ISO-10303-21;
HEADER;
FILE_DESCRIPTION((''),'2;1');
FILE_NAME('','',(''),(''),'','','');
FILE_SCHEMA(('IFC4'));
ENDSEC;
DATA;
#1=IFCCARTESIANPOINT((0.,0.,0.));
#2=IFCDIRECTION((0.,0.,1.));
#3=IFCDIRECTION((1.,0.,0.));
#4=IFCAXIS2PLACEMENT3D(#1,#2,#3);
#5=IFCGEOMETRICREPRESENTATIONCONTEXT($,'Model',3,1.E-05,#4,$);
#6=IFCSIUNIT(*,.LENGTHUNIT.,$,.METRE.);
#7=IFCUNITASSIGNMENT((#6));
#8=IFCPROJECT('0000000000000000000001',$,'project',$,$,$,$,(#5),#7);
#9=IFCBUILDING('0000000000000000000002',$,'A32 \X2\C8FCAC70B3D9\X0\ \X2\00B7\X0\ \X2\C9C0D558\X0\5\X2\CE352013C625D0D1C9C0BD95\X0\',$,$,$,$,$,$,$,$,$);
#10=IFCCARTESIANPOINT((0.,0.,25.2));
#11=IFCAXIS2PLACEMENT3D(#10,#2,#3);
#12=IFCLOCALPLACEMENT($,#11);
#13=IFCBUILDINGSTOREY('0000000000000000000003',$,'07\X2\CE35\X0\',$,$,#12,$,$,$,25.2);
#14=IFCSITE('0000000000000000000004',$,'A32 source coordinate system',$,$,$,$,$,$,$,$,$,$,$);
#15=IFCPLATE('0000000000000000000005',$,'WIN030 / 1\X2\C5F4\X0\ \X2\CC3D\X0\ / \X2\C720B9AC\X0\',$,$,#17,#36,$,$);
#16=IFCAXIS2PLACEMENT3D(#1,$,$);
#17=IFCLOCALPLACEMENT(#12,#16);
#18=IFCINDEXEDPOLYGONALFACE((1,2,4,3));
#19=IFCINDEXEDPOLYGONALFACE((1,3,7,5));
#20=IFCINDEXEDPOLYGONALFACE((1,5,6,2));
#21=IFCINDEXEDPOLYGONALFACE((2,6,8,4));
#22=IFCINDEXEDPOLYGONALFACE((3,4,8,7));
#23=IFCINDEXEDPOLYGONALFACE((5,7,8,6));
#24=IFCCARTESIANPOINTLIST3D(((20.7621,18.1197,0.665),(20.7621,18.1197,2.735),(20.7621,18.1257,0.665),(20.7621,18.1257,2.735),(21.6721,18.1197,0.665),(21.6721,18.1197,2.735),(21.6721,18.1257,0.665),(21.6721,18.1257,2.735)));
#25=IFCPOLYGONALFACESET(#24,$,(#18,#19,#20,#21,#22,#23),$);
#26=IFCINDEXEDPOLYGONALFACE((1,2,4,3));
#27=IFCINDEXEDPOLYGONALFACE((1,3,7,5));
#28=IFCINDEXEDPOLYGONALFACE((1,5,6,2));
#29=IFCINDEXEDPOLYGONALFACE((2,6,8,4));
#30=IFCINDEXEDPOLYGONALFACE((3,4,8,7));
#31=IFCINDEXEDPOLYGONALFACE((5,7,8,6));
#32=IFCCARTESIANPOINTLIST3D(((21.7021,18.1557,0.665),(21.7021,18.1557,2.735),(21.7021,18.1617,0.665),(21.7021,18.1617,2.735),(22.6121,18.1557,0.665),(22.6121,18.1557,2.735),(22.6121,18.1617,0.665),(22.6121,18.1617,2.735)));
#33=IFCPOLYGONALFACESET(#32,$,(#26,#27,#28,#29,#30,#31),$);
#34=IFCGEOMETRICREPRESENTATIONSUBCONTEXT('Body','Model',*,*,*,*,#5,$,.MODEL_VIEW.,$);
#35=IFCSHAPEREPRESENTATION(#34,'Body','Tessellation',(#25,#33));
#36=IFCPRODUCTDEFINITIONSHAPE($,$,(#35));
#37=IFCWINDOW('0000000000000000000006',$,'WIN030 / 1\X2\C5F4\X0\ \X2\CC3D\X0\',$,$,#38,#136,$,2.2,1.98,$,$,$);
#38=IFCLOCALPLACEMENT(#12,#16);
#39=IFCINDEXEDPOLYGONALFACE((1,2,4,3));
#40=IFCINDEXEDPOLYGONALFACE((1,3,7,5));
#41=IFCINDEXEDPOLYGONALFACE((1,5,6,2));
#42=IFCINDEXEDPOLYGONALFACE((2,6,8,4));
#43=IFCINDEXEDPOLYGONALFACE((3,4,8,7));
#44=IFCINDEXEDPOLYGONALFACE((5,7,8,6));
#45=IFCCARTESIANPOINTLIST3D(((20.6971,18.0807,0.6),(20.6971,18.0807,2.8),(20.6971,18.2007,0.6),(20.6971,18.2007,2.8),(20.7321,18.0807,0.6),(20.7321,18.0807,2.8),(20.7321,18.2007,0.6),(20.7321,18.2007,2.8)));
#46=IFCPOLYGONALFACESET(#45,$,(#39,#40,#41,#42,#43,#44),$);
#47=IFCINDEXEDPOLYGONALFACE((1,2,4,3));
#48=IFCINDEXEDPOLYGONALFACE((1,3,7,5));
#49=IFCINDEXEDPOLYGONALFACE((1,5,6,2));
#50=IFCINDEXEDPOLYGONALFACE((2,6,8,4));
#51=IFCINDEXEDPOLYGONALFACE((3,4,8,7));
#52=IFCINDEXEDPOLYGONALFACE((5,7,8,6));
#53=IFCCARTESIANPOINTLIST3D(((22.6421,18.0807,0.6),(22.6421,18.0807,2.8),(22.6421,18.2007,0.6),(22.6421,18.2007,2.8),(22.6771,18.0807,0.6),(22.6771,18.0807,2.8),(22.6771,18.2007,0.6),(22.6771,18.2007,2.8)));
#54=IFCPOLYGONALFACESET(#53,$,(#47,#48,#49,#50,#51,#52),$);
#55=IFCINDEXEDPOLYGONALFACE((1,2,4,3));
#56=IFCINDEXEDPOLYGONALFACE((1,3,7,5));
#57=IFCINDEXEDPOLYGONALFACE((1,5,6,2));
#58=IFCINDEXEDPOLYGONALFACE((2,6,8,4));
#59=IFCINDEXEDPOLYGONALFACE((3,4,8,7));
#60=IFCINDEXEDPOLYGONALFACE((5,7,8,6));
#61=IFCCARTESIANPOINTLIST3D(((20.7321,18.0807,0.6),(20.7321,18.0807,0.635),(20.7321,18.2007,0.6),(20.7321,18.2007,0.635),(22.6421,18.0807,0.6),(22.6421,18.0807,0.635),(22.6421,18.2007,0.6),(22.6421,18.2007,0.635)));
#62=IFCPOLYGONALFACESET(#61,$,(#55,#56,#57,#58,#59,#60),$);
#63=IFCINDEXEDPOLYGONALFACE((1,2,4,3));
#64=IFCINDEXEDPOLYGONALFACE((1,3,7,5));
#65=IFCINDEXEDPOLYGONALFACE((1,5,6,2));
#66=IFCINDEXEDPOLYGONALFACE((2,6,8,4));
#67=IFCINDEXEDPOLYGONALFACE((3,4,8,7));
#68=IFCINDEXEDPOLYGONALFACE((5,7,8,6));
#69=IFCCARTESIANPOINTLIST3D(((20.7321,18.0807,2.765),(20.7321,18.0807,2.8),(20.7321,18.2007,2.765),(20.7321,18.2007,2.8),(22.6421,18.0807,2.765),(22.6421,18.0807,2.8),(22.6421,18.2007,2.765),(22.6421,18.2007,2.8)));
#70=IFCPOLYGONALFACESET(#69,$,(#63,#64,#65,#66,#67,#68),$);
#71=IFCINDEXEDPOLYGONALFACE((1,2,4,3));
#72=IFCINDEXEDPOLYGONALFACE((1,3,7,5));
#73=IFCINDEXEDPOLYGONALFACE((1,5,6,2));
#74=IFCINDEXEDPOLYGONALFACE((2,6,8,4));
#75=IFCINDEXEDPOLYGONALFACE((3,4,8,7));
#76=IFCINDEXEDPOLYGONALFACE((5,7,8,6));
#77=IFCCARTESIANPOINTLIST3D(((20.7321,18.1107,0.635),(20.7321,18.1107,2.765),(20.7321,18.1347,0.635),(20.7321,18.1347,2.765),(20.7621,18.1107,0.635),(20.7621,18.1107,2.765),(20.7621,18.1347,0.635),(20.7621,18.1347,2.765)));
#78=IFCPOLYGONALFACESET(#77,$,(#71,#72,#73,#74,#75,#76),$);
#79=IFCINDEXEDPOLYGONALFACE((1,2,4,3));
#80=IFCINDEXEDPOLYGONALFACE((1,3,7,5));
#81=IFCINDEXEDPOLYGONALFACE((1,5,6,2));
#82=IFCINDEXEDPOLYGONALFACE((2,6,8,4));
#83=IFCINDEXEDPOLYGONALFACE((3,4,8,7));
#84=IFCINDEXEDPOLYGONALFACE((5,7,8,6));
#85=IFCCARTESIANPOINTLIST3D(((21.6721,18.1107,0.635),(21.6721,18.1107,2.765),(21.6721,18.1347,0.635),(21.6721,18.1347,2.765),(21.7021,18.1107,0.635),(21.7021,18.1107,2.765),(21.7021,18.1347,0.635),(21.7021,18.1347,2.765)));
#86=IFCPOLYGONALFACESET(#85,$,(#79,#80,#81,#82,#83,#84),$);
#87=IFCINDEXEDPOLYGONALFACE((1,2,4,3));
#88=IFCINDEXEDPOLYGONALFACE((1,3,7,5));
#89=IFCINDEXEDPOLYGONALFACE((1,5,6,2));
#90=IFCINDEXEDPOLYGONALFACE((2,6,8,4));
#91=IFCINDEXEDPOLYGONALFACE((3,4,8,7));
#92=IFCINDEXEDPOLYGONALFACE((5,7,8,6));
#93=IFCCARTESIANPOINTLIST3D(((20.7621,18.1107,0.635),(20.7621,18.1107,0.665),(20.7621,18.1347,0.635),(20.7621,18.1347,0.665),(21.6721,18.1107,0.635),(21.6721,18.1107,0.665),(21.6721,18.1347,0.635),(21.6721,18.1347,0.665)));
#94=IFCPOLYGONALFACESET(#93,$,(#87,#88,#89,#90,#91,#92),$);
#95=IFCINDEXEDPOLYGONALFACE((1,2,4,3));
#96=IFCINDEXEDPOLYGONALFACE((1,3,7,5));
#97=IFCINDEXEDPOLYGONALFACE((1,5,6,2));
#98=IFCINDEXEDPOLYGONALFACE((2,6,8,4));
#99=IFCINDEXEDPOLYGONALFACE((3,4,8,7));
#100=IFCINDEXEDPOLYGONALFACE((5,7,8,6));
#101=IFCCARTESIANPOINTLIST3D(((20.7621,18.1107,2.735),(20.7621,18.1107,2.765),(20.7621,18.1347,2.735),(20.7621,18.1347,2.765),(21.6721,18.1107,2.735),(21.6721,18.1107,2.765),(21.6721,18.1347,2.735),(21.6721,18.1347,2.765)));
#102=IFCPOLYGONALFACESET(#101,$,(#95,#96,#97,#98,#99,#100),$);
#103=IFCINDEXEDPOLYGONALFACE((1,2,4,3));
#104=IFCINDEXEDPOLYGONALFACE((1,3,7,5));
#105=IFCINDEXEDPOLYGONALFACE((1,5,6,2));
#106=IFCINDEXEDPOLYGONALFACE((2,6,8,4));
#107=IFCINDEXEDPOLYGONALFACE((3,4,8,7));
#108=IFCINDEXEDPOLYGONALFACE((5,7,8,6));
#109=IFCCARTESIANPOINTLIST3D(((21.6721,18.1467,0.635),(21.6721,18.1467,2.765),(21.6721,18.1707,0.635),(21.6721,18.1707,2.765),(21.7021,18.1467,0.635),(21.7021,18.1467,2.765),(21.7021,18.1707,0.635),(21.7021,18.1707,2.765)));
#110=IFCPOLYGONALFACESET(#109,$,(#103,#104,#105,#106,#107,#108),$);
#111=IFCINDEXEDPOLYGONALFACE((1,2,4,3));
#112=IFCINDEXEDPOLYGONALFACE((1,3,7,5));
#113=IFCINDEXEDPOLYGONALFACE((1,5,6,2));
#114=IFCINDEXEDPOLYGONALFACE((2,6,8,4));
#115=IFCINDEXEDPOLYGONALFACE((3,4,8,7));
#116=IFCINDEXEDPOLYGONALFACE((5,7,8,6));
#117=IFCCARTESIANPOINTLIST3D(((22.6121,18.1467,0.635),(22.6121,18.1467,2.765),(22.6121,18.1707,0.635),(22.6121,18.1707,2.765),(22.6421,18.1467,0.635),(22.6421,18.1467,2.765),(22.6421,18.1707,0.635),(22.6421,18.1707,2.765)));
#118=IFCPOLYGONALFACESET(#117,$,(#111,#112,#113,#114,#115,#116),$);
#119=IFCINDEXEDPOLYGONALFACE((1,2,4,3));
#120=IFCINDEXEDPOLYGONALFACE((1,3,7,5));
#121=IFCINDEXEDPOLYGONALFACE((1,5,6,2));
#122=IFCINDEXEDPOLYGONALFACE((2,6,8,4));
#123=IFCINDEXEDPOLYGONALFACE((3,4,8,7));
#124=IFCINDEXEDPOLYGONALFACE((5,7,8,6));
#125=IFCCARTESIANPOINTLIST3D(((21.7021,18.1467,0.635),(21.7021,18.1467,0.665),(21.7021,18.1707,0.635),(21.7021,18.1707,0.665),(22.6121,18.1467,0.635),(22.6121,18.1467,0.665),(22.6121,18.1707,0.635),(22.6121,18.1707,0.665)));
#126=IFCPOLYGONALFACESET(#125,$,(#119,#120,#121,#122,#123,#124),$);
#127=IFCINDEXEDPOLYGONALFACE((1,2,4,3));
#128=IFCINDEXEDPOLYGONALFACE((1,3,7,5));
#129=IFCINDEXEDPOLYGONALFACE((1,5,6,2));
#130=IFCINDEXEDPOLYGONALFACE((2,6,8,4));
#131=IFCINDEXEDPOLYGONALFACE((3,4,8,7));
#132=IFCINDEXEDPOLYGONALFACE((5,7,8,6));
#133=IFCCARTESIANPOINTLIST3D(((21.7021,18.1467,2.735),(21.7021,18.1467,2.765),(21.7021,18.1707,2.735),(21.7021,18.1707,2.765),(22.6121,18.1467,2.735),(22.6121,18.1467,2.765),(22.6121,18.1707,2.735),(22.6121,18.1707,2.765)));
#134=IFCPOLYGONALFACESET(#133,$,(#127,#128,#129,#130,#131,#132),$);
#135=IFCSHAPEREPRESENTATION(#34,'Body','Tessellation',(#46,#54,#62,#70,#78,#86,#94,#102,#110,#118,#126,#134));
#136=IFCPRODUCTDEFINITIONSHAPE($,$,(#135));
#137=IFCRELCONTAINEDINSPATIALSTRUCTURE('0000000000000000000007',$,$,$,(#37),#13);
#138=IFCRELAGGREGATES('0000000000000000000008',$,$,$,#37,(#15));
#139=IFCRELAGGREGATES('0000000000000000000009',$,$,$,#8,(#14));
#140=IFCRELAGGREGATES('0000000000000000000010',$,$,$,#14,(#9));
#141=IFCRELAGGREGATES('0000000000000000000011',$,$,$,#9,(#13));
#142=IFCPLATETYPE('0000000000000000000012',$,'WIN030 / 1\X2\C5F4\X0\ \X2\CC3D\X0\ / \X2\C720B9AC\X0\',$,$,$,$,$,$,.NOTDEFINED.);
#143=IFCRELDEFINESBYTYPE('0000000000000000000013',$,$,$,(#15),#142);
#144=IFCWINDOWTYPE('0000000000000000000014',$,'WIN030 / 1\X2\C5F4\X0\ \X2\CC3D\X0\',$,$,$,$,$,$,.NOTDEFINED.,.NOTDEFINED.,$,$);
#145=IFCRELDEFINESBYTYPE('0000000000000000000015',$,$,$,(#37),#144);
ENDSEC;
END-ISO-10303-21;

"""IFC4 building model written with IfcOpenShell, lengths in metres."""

from ifc_helpers import new_model, si_unit, frame, origin, origin_with_axes, place, context, subcontext, project, spatial, polyline, outline, extrude, source, transform, mapped, type_object, type_shapes, element, aggregate, save


model = new_model("IFC4")

# Units and contexts
model_context = context("Model", 3, precision=1e-05, world=origin_with_axes())
body_context = subcontext(model_context, "Body", "Model", "MODEL_VIEW")
ifc_project = project(units=[si_unit("LENGTHUNIT", "METRE")], contexts=[model_context])

# Plate
storey_placement = place(None, frame((0.0, 0.0, 25.2), z_axis=(0.0, 0.0, 1.0), x_axis=(1.0, 0.0, 0.0)))
plate_type_1 = type_object("IfcPlateType", Name="WIN030 / 1열 창 / 유리", PredefinedType="NOTDEFINED")
shared_shape_1 = source(origin(), body_context, "Body", "SweptSolid", [
    extrude(outline(polyline([(20.7621, 18.1197), (20.7621, 18.1257), (21.6721, 18.1257), (21.6721, 18.1197), (20.7621, 18.1197)])), frame((0.0, 0.0, 0.665)), (0.0, 0.0, 1.0), 2.07),
    extrude(outline(polyline([(21.7021, 18.1557), (21.7021, 18.1617), (22.6121, 18.1617), (22.6121, 18.1557), (21.7021, 18.1557)])), frame((0.0, 0.0, 0.665)), (0.0, 0.0, 1.0), 2.07),
])
type_shapes(plate_type_1, [shared_shape_1])
window_1_placement = place(storey_placement, origin_with_axes())
plate_1_placement = place(window_1_placement, origin_with_axes())
plate_1 = element("IfcPlate", 1, at=plate_1_placement, type_object=plate_type_1, Name="WIN030 / 1열 창 / 유리", context=body_context, shape_type="MappedRepresentation", body=[
    mapped(shared_shape_1, transform((0.0, 0.0, 0.0), scale=1.0)),
])

# Site, building, storey
site = spatial("IfcSite", under=ifc_project, Name="A32 source coordinate system")
building = spatial("IfcBuilding", under=site, Name="A32 주거동 · 지하5층–옥탑지붕")
storey = spatial("IfcBuildingStorey", under=building, at=storey_placement, Name="07층", Elevation=25.2)

# Window
window_type_1 = type_object("IfcWindowType", Name="WIN030 / 1열 창", PartitioningType="NOTDEFINED", PredefinedType="NOTDEFINED")
shared_shape_2 = source(origin(), body_context, "Body", "SweptSolid", [
    extrude(outline(polyline([(20.6971, 18.0807), (20.6971, 18.2007), (20.7321, 18.2007), (20.7321, 18.0807), (20.6971, 18.0807)])), frame((0.0, 0.0, 0.6)), (0.0, 0.0, 1.0), 2.2),
    extrude(outline(polyline([(22.6421, 18.0807), (22.6421, 18.2007), (22.6771, 18.2007), (22.6771, 18.0807), (22.6421, 18.0807)])), frame((0.0, 0.0, 0.6)), (0.0, 0.0, 1.0), 2.2),
    extrude(outline(polyline([(20.7321, 18.0807), (20.7321, 18.2007), (22.6421, 18.2007), (22.6421, 18.0807), (20.7321, 18.0807)])), frame((0.0, 0.0, 0.6)), (0.0, 0.0, 1.0), 0.035),
    extrude(outline(polyline([(20.7321, 18.0807), (20.7321, 18.2007), (22.6421, 18.2007), (22.6421, 18.0807), (20.7321, 18.0807)])), frame((0.0, 0.0, 2.765)), (0.0, 0.0, 1.0), 0.035),
    extrude(outline(polyline([(20.7321, 18.1107), (20.7321, 18.1347), (20.7621, 18.1347), (20.7621, 18.1107), (20.7321, 18.1107)])), frame((0.0, 0.0, 0.635)), (0.0, 0.0, 1.0), 2.13),
    extrude(outline(polyline([(21.6721, 18.1107), (21.6721, 18.1347), (21.7021, 18.1347), (21.7021, 18.1107), (21.6721, 18.1107)])), frame((0.0, 0.0, 0.635)), (0.0, 0.0, 1.0), 2.13),
    extrude(outline(polyline([(20.7621, 18.1107), (20.7621, 18.1347), (21.6721, 18.1347), (21.6721, 18.1107), (20.7621, 18.1107)])), frame((0.0, 0.0, 0.635)), (0.0, 0.0, 1.0), 0.03),
    extrude(outline(polyline([(20.7621, 18.1107), (20.7621, 18.1347), (21.6721, 18.1347), (21.6721, 18.1107), (20.7621, 18.1107)])), frame((0.0, 0.0, 2.735)), (0.0, 0.0, 1.0), 0.03),
    extrude(outline(polyline([(21.6721, 18.1467), (21.6721, 18.1707), (21.7021, 18.1707), (21.7021, 18.1467), (21.6721, 18.1467)])), frame((0.0, 0.0, 0.635)), (0.0, 0.0, 1.0), 2.13),
    extrude(outline(polyline([(22.6121, 18.1467), (22.6121, 18.1707), (22.6421, 18.1707), (22.6421, 18.1467), (22.6121, 18.1467)])), frame((0.0, 0.0, 0.635)), (0.0, 0.0, 1.0), 2.13),
    extrude(outline(polyline([(21.7021, 18.1467), (21.7021, 18.1707), (22.6121, 18.1707), (22.6121, 18.1467), (21.7021, 18.1467)])), frame((0.0, 0.0, 0.635)), (0.0, 0.0, 1.0), 0.03),
    extrude(outline(polyline([(21.7021, 18.1467), (21.7021, 18.1707), (22.6121, 18.1707), (22.6121, 18.1467), (21.7021, 18.1467)])), frame((0.0, 0.0, 2.735)), (0.0, 0.0, 1.0), 0.03),
])
type_shapes(window_type_1, [shared_shape_2])
window_1 = element("IfcWindow", 2, at=window_1_placement, inside=storey, type_object=window_type_1, Name="WIN030 / 1열 창", OverallHeight=2.2, OverallWidth=1.98, context=body_context, shape_type="MappedRepresentation", body=[
    mapped(shared_shape_2, transform((0.0, 0.0, 0.0), scale=1.0)),
])
aggregate(window_1, [plate_1])

save(model, "model.ifc")
